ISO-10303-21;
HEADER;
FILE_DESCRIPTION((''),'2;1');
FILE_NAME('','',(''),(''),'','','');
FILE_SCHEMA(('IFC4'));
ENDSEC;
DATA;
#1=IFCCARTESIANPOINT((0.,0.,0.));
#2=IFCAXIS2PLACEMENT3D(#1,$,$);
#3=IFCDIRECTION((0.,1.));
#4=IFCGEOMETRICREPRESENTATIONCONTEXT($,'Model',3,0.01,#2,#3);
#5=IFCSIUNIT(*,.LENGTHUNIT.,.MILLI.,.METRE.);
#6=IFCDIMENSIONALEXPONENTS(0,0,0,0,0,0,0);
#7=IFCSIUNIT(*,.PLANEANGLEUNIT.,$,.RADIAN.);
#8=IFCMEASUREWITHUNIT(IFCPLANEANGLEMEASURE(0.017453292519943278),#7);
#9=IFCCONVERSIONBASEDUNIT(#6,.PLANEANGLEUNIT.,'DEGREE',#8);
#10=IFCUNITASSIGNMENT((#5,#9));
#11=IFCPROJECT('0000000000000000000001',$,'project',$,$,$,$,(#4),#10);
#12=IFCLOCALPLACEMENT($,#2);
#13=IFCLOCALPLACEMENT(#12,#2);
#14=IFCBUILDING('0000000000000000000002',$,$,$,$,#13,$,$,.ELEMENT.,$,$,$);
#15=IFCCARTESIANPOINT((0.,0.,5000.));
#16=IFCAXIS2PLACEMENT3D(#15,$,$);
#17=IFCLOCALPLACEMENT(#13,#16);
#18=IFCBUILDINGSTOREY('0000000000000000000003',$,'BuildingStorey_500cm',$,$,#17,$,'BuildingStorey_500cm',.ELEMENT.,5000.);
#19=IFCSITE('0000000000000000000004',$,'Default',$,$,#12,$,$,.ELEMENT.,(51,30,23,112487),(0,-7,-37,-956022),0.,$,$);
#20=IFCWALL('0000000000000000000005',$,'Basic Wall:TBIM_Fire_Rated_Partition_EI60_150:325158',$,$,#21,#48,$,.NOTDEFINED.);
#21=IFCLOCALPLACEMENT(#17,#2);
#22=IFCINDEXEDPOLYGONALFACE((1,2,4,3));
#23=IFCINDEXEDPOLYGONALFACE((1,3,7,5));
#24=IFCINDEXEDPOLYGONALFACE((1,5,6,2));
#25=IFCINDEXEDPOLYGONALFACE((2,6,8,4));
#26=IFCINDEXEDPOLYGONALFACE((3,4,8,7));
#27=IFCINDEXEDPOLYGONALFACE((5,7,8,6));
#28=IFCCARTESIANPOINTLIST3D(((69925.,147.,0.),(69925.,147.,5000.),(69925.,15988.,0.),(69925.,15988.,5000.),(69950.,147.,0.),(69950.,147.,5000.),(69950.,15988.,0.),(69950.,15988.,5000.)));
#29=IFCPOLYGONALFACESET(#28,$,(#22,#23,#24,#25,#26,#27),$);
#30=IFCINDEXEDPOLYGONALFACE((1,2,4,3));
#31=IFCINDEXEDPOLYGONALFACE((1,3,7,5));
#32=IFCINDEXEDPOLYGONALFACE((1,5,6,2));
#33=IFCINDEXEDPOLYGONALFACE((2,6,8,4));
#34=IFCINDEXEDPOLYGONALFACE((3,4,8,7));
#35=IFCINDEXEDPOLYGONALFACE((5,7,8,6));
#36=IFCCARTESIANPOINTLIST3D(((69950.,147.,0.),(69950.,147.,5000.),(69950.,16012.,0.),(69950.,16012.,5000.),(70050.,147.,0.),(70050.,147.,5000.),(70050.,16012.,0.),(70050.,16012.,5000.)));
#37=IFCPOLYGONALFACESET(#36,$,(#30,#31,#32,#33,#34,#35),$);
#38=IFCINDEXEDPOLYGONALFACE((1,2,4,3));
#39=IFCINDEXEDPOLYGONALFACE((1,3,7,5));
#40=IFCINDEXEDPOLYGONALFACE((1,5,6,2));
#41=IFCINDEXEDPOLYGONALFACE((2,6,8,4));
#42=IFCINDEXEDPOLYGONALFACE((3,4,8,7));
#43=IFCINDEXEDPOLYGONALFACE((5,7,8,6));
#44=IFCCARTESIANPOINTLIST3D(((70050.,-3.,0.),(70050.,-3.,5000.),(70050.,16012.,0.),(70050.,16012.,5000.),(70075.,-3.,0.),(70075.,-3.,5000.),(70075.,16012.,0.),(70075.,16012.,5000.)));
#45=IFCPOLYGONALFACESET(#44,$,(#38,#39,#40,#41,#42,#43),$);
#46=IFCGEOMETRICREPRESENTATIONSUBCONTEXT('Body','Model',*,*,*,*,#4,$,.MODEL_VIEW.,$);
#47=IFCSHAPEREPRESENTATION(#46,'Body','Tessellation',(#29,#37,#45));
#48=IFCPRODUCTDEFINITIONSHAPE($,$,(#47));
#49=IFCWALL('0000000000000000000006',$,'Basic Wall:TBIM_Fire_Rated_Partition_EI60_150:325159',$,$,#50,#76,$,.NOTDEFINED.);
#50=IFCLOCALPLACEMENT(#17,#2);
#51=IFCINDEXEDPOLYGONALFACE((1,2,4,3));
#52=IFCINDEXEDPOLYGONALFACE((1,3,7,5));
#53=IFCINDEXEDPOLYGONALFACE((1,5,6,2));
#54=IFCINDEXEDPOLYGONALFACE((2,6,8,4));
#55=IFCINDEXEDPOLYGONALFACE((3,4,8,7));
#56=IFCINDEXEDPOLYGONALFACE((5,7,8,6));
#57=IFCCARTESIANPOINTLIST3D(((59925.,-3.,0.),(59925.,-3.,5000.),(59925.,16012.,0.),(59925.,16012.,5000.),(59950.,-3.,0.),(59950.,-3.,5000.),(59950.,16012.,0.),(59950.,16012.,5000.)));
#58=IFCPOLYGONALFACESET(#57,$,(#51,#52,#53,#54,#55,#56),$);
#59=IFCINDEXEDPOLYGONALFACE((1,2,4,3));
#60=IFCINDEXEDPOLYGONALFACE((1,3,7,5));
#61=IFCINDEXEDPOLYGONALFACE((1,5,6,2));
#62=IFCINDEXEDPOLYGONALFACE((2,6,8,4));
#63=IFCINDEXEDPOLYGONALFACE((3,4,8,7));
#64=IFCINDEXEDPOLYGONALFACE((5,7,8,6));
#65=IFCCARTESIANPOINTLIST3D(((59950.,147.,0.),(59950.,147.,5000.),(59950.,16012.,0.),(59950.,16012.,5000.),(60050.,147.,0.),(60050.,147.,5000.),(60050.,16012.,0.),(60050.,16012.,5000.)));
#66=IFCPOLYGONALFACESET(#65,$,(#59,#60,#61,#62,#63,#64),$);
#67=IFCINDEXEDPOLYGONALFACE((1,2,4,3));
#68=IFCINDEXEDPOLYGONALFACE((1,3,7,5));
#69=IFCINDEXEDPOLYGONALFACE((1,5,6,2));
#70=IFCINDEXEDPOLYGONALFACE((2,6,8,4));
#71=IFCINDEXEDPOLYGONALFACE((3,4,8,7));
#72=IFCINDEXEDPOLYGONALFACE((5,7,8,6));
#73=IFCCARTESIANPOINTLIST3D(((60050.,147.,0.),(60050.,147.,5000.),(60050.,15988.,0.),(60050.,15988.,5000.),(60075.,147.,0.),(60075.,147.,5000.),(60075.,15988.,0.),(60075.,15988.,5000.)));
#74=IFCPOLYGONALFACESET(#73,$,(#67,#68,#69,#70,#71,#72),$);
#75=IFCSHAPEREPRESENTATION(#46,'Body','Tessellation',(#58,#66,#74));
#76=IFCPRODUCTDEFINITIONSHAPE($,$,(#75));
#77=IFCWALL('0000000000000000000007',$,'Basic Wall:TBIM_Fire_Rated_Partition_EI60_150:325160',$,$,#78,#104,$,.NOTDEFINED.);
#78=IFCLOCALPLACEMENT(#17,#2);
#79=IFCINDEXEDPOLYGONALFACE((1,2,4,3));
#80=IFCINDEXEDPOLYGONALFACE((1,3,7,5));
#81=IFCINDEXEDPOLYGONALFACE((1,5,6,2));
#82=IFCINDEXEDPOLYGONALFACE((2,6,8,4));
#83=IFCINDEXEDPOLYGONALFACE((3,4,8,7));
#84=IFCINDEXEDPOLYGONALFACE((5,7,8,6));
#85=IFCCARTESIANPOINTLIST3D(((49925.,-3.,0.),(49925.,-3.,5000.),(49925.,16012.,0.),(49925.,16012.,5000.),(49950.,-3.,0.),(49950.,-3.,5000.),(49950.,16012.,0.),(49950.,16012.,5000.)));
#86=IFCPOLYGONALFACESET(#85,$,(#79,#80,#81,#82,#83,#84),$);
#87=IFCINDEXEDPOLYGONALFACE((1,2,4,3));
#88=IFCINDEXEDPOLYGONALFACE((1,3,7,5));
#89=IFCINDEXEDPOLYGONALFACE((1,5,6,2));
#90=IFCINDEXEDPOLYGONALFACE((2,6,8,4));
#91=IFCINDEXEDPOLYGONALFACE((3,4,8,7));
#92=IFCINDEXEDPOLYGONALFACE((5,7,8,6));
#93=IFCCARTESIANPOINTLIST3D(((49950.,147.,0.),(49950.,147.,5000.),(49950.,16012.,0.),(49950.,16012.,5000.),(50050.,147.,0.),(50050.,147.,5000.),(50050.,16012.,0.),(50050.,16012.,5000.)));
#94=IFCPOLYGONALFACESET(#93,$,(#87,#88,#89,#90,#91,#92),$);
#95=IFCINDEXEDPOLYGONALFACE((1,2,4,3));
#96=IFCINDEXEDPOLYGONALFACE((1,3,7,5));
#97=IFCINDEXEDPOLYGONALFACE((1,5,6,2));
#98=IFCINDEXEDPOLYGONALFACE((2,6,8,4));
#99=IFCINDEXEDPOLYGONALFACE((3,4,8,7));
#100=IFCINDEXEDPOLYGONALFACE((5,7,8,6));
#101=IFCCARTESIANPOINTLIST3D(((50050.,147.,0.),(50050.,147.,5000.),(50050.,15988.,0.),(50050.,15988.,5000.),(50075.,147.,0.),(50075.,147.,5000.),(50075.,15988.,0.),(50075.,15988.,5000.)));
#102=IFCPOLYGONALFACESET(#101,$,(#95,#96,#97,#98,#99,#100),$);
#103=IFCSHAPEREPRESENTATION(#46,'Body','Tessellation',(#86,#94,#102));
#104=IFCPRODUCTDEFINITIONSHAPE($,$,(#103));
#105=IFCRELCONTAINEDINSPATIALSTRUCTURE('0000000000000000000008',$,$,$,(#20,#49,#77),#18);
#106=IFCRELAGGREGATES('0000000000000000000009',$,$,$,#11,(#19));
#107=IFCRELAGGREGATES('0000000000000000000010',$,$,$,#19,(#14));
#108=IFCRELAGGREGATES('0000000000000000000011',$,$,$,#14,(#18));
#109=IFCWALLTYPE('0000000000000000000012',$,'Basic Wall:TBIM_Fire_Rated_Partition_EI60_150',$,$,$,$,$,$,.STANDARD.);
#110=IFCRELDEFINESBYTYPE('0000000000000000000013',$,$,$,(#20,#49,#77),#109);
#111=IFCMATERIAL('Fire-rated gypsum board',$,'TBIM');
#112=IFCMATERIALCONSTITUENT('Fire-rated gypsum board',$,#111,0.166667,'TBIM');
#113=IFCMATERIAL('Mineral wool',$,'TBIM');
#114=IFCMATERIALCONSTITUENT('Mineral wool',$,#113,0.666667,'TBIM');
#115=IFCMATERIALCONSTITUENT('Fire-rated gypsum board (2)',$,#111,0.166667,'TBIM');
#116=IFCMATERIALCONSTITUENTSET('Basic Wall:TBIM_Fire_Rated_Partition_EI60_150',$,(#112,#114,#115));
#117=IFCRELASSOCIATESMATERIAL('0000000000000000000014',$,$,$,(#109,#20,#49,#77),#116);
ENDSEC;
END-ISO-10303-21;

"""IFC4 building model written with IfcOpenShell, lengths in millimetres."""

from ifc_helpers import new_model, entity, si_unit, converted_unit, direction, frame, origin, place, context, subcontext, project, spatial, indexed_curve, outline, extrude, material, constituent, constituent_set, type_object, element, save


model = new_model("IFC4")

# Units and contexts
model_context = context("Model", 3, precision=0.01, world=origin(), true_north=direction((0.0, 1.0)))
body_context = subcontext(model_context, "Body", "Model", "MODEL_VIEW")
ifc_project = project(units=[si_unit("LENGTHUNIT", "METRE", prefix="MILLI"), converted_unit("PLANEANGLEUNIT", "DEGREE", entity("IfcPlaneAngleMeasure", 0.017453292519943278), si_unit("PLANEANGLEUNIT", "RADIAN"), dimensions=[0, 0, 0, 0, 0, 0, 0])], contexts=[model_context])

# Site, building, storey
site_placement = place(None, origin())
site = spatial("IfcSite", under=ifc_project, at=site_placement, Name="Default", CompositionType="ELEMENT", RefLatitude=(51, 30, 23, 112487), RefLongitude=(0, -7, -37, -956022), RefElevation=0.0)
building_placement = place(site_placement, origin())
building = spatial("IfcBuilding", under=site, at=building_placement, CompositionType="ELEMENT")
storey_placement = place(building_placement, frame((0.0, 0.0, 5000.0)))
storey = spatial("IfcBuildingStorey", under=building, at=storey_placement, Name="BuildingStorey_500cm", LongName="BuildingStorey_500cm", CompositionType="ELEMENT", Elevation=5000.0)

# Shared definitions
ifc_material_1 = material(Name="Mineral wool", Category="TBIM")

# Walls
ifc_material_2 = material(Name="Fire-rated gypsum board", Category="TBIM")
ifc_constituent_1 = constituent(ifc_material_2, Name="Fire-rated gypsum board", Category="TBIM", fraction=0.166667)
ifc_constituent_2 = constituent(ifc_material_1, Name="Mineral wool", Category="TBIM", fraction=0.666667)
ifc_constituent_3 = constituent(ifc_material_2, Name="Fire-rated gypsum board (2)", Category="TBIM", fraction=0.166667)
ifc_constituent_set_1 = constituent_set(constituents=[ifc_constituent_1, ifc_constituent_2, ifc_constituent_3], Name="Basic Wall:TBIM_Fire_Rated_Partition_EI60_150")
wall_type_1 = type_object("IfcWallType", Name="Basic Wall:TBIM_Fire_Rated_Partition_EI60_150", PredefinedType="STANDARD", material=ifc_constituent_set_1)
wall_1_placement = place(storey_placement, frame((70000.0, 147.0, 0.0), z_axis=(0.0, 0.0, 1.0), x_axis=(0.0, 1.0, 0.0)))
element("IfcWall", 1, at=wall_1_placement, inside=storey, type_object=wall_type_1, material=ifc_constituent_set_1, Name="Basic Wall:TBIM_Fire_Rated_Partition_EI60_150:325158", PredefinedType="NOTDEFINED", context=body_context, shape_type="SweptSolid", body=[
    extrude(outline(indexed_curve([(-12.5, -7920.5), (12.5, -7920.5), (12.5, 7920.5), (-12.5, 7920.5), (-12.5, -7920.5)], self_intersect=False)), frame((7920.5, 62.5, 0.0), z_axis=(0.0, 0.0, 1.0), x_axis=(0.0, -1.0, 0.0)), (0.0, 0.0, 1.0), 5000.0),
    extrude(outline(indexed_curve([(-7932.5, -50.0), (7932.5, -50.0), (7932.5, 50.0), (-7932.5, 50.0), (-7932.5, -50.0)], self_intersect=False)), frame((7932.5, 0.0, 0.0)), (0.0, 0.0, 1.0), 5000.0),
    extrude(outline(indexed_curve([(-12.5, -8007.5), (12.5, -8007.5), (12.5, 8007.5), (-12.5, 8007.5), (-12.5, -8007.5)], self_intersect=False)), frame((7857.5, -62.5, 0.0), z_axis=(0.0, 0.0, 1.0), x_axis=(0.0, 1.0, 0.0)), (0.0, 0.0, 1.0), 5000.0),
])
wall_2_placement = place(storey_placement, frame((60000.0, 147.0, 0.0), z_axis=(0.0, 0.0, 1.0), x_axis=(0.0, 1.0, 0.0)))
element("IfcWall", 2, at=wall_2_placement, inside=storey, type_object=wall_type_1, material=ifc_constituent_set_1, Name="Basic Wall:TBIM_Fire_Rated_Partition_EI60_150:325159", PredefinedType="NOTDEFINED", context=body_context, shape_type="SweptSolid", body=[
    extrude(outline(indexed_curve([(-12.5, -8007.5), (12.5, -8007.5), (12.5, 8007.5), (-12.5, 8007.5), (-12.5, -8007.5)], self_intersect=False)), frame((7857.5, 62.5, 0.0), z_axis=(0.0, 0.0, 1.0), x_axis=(0.0, -1.0, 0.0)), (0.0, 0.0, 1.0), 5000.0),
    extrude(outline(indexed_curve([(-7932.5, -50.0), (7932.5, -50.0), (7932.5, 50.0), (-7932.5, 50.0), (-7932.5, -50.0)], self_intersect=False)), frame((7932.5, 0.0, 0.0)), (0.0, 0.0, 1.0), 5000.0),
    extrude(outline(indexed_curve([(-12.5, -7920.5), (12.5, -7920.5), (12.5, 7920.5), (-12.5, 7920.5), (-12.5, -7920.5)], self_intersect=False)), frame((7920.5, -62.5, 0.0), z_axis=(0.0, 0.0, 1.0), x_axis=(0.0, 1.0, 0.0)), (0.0, 0.0, 1.0), 5000.0),
])
wall_3_placement = place(storey_placement, frame((50000.0, 147.0, 0.0), z_axis=(0.0, 0.0, 1.0), x_axis=(0.0, 1.0, 0.0)))
element("IfcWall", 3, at=wall_3_placement, inside=storey, type_object=wall_type_1, material=ifc_constituent_set_1, Name="Basic Wall:TBIM_Fire_Rated_Partition_EI60_150:325160", PredefinedType="NOTDEFINED", context=body_context, shape_type="SweptSolid", body=[
    extrude(outline(indexed_curve([(-12.5, -8007.5), (12.5, -8007.5), (12.5, 8007.5), (-12.5, 8007.5), (-12.5, -8007.5)], self_intersect=False)), frame((7857.5, 62.5, 0.0), z_axis=(0.0, 0.0, 1.0), x_axis=(0.0, -1.0, 0.0)), (0.0, 0.0, 1.0), 5000.0),
    extrude(outline(indexed_curve([(-7932.5, -50.0), (7932.5, -50.0), (7932.5, 50.0), (-7932.5, 50.0), (-7932.5, -50.0)], self_intersect=False)), frame((7932.5, 0.0, 0.0)), (0.0, 0.0, 1.0), 5000.0),
    extrude(outline(indexed_curve([(-12.5, -7920.5), (12.5, -7920.5), (12.5, 7920.5), (-12.5, 7920.5), (-12.5, -7920.5)], self_intersect=False)), frame((7920.5, -62.5, 0.0), z_axis=(0.0, 0.0, 1.0), x_axis=(0.0, 1.0, 0.0)), (0.0, 0.0, 1.0), 5000.0),
])

save(model, "model.ifc")
